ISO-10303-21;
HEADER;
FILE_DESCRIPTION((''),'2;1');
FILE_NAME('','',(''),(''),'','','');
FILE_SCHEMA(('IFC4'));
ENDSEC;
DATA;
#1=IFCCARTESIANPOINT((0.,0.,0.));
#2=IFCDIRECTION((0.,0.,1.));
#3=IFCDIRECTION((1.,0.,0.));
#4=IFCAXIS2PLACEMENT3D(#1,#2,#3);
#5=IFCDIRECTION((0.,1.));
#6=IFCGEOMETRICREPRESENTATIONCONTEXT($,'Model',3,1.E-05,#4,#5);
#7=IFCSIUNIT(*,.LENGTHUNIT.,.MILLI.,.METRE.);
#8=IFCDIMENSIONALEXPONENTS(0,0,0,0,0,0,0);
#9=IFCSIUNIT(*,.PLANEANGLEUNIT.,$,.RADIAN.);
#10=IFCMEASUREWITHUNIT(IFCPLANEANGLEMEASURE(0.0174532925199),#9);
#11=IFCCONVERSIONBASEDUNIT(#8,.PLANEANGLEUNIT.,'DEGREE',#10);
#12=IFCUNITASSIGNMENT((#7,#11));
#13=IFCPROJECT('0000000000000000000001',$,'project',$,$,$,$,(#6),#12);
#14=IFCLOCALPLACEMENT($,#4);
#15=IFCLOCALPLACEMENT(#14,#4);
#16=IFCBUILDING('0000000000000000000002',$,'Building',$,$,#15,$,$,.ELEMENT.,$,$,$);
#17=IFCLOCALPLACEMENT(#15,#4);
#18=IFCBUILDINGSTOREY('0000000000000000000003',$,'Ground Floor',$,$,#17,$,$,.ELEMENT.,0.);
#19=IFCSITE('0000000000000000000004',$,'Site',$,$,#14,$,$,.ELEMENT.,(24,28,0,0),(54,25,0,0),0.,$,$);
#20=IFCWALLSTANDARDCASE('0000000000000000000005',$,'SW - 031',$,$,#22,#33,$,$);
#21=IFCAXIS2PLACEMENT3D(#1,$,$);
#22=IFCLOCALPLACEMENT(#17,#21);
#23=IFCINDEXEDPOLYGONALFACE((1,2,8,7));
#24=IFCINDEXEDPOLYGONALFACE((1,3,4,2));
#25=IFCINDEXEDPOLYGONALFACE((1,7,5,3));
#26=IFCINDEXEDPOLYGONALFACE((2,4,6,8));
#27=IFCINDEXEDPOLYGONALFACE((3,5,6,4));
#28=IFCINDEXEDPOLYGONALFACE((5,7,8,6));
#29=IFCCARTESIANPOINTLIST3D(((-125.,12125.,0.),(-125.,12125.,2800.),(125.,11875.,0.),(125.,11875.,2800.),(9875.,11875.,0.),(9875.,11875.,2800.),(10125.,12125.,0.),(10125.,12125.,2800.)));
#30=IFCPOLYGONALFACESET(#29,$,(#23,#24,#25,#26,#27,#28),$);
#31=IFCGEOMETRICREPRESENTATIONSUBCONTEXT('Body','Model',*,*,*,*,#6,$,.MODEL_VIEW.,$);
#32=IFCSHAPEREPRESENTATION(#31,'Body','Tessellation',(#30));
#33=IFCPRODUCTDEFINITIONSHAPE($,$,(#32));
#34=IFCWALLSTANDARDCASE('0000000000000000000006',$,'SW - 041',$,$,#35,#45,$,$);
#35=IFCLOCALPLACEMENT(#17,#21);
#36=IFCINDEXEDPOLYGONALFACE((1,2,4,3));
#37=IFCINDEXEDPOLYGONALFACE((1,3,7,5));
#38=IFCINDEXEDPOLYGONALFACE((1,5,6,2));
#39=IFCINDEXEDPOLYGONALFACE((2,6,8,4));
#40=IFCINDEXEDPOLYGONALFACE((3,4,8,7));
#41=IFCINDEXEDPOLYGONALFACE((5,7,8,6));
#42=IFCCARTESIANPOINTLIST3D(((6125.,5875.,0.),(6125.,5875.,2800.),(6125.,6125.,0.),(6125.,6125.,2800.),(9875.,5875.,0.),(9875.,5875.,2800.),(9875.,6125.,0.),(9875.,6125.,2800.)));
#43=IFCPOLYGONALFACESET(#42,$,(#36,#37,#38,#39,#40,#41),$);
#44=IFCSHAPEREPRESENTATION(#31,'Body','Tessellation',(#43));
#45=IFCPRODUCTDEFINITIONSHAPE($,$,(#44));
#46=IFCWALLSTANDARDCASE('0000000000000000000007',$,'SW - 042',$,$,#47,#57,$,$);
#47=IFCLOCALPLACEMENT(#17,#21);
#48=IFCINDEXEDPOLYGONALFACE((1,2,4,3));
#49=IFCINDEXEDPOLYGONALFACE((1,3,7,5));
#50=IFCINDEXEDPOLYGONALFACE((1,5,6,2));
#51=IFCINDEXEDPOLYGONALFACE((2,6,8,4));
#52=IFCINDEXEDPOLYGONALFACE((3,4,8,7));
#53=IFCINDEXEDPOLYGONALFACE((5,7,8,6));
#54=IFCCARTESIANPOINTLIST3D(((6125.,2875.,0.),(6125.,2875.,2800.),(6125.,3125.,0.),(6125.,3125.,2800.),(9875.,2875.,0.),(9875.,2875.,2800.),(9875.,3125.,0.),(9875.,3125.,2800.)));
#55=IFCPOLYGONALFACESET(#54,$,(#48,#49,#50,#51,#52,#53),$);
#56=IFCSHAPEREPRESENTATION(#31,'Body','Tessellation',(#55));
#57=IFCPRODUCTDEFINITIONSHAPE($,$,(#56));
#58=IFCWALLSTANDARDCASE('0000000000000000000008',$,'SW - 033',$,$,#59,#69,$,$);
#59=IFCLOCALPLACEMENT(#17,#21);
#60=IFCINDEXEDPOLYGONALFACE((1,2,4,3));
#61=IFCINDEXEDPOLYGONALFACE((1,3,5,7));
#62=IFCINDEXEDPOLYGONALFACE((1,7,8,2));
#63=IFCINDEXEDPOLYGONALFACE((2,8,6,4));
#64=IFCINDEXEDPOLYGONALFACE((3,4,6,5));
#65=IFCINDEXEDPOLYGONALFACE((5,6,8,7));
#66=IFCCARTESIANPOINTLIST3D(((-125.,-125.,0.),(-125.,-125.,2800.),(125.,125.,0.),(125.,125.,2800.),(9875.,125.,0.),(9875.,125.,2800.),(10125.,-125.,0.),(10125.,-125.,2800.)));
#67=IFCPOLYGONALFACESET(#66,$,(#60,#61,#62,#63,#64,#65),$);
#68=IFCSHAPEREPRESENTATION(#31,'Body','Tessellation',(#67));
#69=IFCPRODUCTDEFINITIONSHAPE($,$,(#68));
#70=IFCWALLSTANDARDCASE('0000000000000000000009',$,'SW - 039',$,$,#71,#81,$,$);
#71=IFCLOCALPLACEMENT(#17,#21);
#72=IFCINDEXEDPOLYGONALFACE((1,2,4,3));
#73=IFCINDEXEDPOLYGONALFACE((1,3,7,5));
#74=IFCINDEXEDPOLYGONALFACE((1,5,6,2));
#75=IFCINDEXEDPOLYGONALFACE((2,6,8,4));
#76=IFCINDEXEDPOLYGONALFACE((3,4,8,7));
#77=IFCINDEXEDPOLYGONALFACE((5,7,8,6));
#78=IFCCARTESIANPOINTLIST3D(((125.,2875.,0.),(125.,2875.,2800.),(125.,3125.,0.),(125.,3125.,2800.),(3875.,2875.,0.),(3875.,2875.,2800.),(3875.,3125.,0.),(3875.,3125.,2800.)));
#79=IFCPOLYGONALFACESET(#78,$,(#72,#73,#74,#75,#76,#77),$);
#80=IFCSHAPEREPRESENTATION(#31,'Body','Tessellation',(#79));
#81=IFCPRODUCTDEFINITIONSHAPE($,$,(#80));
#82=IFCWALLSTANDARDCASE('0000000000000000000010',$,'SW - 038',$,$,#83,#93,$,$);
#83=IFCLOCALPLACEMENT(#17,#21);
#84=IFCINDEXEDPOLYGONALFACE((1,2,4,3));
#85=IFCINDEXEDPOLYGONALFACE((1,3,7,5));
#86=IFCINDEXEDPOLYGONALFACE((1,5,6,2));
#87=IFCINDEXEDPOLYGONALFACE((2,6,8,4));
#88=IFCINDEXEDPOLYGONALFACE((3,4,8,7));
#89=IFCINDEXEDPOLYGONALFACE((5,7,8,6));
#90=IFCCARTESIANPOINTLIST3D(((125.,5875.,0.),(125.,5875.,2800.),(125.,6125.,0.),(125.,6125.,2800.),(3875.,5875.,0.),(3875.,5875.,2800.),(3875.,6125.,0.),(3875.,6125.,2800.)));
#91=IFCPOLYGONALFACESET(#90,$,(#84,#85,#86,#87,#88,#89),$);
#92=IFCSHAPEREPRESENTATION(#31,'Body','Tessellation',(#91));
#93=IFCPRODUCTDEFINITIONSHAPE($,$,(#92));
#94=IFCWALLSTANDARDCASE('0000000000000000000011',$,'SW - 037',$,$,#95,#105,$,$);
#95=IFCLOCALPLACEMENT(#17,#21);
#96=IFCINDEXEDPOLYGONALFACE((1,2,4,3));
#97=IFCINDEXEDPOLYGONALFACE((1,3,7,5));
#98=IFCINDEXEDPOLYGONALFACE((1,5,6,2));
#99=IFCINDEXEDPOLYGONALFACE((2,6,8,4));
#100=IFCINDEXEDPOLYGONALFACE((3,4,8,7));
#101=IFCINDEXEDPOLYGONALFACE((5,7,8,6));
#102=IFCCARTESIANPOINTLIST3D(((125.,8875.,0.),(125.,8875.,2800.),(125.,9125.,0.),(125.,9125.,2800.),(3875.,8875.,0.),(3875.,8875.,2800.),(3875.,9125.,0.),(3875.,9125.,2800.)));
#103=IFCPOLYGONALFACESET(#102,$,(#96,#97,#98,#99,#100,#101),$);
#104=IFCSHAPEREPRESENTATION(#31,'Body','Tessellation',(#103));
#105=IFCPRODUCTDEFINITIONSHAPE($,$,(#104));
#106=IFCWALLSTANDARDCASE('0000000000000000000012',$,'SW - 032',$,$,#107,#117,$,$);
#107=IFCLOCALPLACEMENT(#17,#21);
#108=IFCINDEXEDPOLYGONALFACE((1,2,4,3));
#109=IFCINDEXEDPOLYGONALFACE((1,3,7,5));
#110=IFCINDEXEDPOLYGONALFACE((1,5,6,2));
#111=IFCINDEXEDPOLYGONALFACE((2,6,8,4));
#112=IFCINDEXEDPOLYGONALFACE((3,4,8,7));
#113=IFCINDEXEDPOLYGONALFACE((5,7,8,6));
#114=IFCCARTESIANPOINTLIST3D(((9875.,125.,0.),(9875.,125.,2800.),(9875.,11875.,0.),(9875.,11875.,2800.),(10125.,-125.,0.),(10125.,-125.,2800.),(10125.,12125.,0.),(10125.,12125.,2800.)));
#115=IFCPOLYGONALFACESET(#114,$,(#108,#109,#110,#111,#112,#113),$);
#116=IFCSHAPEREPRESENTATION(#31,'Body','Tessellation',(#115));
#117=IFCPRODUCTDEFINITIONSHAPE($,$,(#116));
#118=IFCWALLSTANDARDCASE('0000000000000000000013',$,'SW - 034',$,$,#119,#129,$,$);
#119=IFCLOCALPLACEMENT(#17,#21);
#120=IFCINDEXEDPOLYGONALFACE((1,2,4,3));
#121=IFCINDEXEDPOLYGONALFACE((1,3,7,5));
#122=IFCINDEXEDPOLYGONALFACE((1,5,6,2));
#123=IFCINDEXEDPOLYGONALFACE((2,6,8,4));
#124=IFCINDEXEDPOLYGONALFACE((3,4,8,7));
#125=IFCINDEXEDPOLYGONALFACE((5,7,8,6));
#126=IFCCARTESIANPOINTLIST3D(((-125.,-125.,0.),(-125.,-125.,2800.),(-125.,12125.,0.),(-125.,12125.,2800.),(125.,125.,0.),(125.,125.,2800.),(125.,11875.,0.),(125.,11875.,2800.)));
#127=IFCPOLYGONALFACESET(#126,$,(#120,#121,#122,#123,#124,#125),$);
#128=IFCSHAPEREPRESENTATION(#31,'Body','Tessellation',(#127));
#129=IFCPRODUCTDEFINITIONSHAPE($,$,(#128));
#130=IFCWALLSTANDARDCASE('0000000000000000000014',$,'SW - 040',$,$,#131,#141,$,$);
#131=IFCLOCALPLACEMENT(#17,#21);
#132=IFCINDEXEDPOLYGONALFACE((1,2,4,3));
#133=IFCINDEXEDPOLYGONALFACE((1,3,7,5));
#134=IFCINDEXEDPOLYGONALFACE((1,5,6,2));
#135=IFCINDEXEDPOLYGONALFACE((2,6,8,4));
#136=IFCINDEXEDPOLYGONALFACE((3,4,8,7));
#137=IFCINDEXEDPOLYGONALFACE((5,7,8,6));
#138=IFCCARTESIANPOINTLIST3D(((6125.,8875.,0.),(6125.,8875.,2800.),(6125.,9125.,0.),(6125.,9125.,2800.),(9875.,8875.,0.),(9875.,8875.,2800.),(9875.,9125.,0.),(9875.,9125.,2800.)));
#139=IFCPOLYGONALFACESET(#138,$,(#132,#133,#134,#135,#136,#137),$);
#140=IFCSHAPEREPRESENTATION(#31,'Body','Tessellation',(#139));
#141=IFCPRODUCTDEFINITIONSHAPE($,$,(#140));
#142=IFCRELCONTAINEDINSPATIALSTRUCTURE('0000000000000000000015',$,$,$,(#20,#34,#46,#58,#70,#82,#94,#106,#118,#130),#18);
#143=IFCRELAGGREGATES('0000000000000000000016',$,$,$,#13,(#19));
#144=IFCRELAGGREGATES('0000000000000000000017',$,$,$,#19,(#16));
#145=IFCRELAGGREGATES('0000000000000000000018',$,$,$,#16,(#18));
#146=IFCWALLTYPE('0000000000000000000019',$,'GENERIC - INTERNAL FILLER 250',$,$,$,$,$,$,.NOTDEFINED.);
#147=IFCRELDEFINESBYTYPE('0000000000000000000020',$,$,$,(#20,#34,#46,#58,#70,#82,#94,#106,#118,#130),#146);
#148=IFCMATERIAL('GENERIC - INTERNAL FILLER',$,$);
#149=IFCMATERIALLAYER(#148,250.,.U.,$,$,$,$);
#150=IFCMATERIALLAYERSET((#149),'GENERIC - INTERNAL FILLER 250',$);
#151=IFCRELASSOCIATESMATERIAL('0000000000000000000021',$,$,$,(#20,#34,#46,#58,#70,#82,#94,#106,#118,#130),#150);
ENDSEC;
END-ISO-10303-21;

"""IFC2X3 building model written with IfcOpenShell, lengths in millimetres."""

from ifc_helpers import new_model, entity, si_unit, converted_unit, direction, frame, origin_with_axes, place, context, subcontext, project, spatial, polyline, outline, extrude, material, layer, layer_set, layer_usage, type_object, element, save


model = new_model("IFC2X3")

# Units and contexts
model_context = context("Model", 3, precision=1e-05, world=origin_with_axes(), true_north=direction((0.0, 1.0)))
body_context = subcontext(model_context, "Body", "Model", "MODEL_VIEW")
ifc_project = project(units=[si_unit("LENGTHUNIT", "METRE", prefix="MILLI"), converted_unit("PLANEANGLEUNIT", "DEGREE", entity("IfcPlaneAngleMeasure", 0.0174532925199), si_unit("PLANEANGLEUNIT", "RADIAN"), dimensions=[0, 0, 0, 0, 0, 0, 0])], contexts=[model_context])

# Site, building, storey
site_placement = place(None, origin_with_axes())
site = spatial("IfcSite", under=ifc_project, at=site_placement, Name="Site", CompositionType="ELEMENT", RefLatitude=(24, 28, 0, 0), RefLongitude=(54, 25, 0, 0), RefElevation=0.0)
building_placement = place(site_placement, origin_with_axes())
building = spatial("IfcBuilding", under=site, at=building_placement, Name="Building", CompositionType="ELEMENT")
storey_placement = place(building_placement, origin_with_axes())
storey = spatial("IfcBuildingStorey", under=building, at=storey_placement, Name="Ground Floor", CompositionType="ELEMENT", Elevation=0.0)

# Wall
ifc_material = material(Name="GENERIC - INTERNAL FILLER")
ifc_layer = layer(ifc_material, 250.0, ventilated="UNKNOWN")
ifc_layer_set = layer_set([ifc_layer], Name="GENERIC - INTERNAL FILLER 250")
ifc_layer_usage_1 = layer_usage(ifc_layer_set, "AXIS2", "POSITIVE", -125.0)
wall_type = type_object("IfcWallType", Name="GENERIC - INTERNAL FILLER 250", PredefinedType="NOTDEFINED")
wall_1_placement = place(storey_placement, frame((0.0, 12000.0, 0.0), z_axis=(0.0, 0.0, 1.0), x_axis=(1.0, 0.0, 0.0)))
element("IfcWallStandardCase", 1, at=wall_1_placement, inside=storey, type_object=wall_type, material=ifc_layer_usage_1, Name="SW - 031", context=body_context, shape_type="SweptSolid", body=[
    extrude(outline(polyline([(125.0, -125.0), (9875.0, -125.0), (10125.0, 125.0), (-125.0, 125.0), (125.0, -125.0)])), origin_with_axes(), (0.0, 0.0, 1.0), 2800.0),
])

# Walls
ifc_layer_usage_2 = layer_usage(ifc_layer_set, "AXIS2", "POSITIVE", -125.0)
wall_2_placement = place(storey_placement, frame((6000.0, 6000.0, 0.0), z_axis=(0.0, 0.0, 1.0), x_axis=(1.0, 0.0, 0.0)))
element("IfcWallStandardCase", 2, at=wall_2_placement, inside=storey, type_object=wall_type, material=ifc_layer_usage_2, Name="SW - 041", context=body_context, shape_type="SweptSolid", body=[
    extrude(outline(polyline([(125.0, -125.0), (3875.0, -125.0), (3875.0, 125.0), (125.0, 125.0), (125.0, -125.0)])), origin_with_axes(), (0.0, 0.0, 1.0), 2800.0),
])
ifc_layer_usage_3 = layer_usage(ifc_layer_set, "AXIS2", "POSITIVE", -125.0)
wall_3_placement = place(storey_placement, frame((6000.0, 3000.0, 0.0), z_axis=(0.0, 0.0, 1.0), x_axis=(1.0, 0.0, 0.0)))
element("IfcWallStandardCase", 3, at=wall_3_placement, inside=storey, type_object=wall_type, material=ifc_layer_usage_3, Name="SW - 042", context=body_context, shape_type="SweptSolid", body=[
    extrude(outline(polyline([(125.0, -125.0), (3875.0, -125.0), (3875.0, 125.0), (125.0, 125.0), (125.0, -125.0)])), origin_with_axes(), (0.0, 0.0, 1.0), 2800.0),
])
ifc_layer_usage_4 = layer_usage(ifc_layer_set, "AXIS2", "POSITIVE", -125.0)
wall_4_placement = place(storey_placement, frame((10000.0, 0.0, 0.0), z_axis=(0.0, 0.0, 1.0), x_axis=(-1.0, 0.0, 0.0)))
element("IfcWallStandardCase", 4, at=wall_4_placement, inside=storey, type_object=wall_type, material=ifc_layer_usage_4, Name="SW - 033", context=body_context, shape_type="SweptSolid", body=[
    extrude(outline(polyline([(125.0, -125.0), (9875.0, -125.0), (10125.0, 125.0), (-125.0, 125.0), (125.0, -125.0)])), origin_with_axes(), (0.0, 0.0, 1.0), 2800.0),
])

# Walls
ifc_layer_usage_5 = layer_usage(ifc_layer_set, "AXIS2", "POSITIVE", -125.0)
wall_5_placement = place(storey_placement, frame((0.0, 3000.0, 0.0), z_axis=(0.0, 0.0, 1.0), x_axis=(1.0, 0.0, 0.0)))
element("IfcWallStandardCase", 5, at=wall_5_placement, inside=storey, type_object=wall_type, material=ifc_layer_usage_5, Name="SW - 039", context=body_context, shape_type="SweptSolid", body=[
    extrude(outline(polyline([(125.0, -125.0), (3875.0, -125.0), (3875.0, 125.0), (125.0, 125.0), (125.0, -125.0)])), origin_with_axes(), (0.0, 0.0, 1.0), 2800.0),
])
ifc_layer_usage_6 = layer_usage(ifc_layer_set, "AXIS2", "POSITIVE", -125.0)
wall_6_placement = place(storey_placement, frame((0.0, 6000.0, 0.0), z_axis=(0.0, 0.0, 1.0), x_axis=(1.0, 0.0, 0.0)))
element("IfcWallStandardCase", 6, at=wall_6_placement, inside=storey, type_object=wall_type, material=ifc_layer_usage_6, Name="SW - 038", context=body_context, shape_type="SweptSolid", body=[
    extrude(outline(polyline([(125.0, -125.0), (3875.0, -125.0), (3875.0, 125.0), (125.0, 125.0), (125.0, -125.0)])), origin_with_axes(), (0.0, 0.0, 1.0), 2800.0),
])
ifc_layer_usage_7 = layer_usage(ifc_layer_set, "AXIS2", "POSITIVE", -125.0)
wall_7_placement = place(storey_placement, frame((0.0, 9000.0, 0.0), z_axis=(0.0, 0.0, 1.0), x_axis=(1.0, 0.0, 0.0)))
element("IfcWallStandardCase", 7, at=wall_7_placement, inside=storey, type_object=wall_type, material=ifc_layer_usage_7, Name="SW - 037", context=body_context, shape_type="SweptSolid", body=[
    extrude(outline(polyline([(125.0, -125.0), (3875.0, -125.0), (3875.0, 125.0), (125.0, 125.0), (125.0, -125.0)])), origin_with_axes(), (0.0, 0.0, 1.0), 2800.0),
])
ifc_layer_usage_8 = layer_usage(ifc_layer_set, "AXIS2", "POSITIVE", -125.0)
wall_8_placement = place(storey_placement, frame((10000.0, 12000.0, 0.0), z_axis=(0.0, 0.0, 1.0), x_axis=(0.0, -1.0, 0.0)))
element("IfcWallStandardCase", 8, at=wall_8_placement, inside=storey, type_object=wall_type, material=ifc_layer_usage_8, Name="SW - 032", context=body_context, shape_type="SweptSolid", body=[
    extrude(outline(polyline([(125.0, -125.0), (11875.0, -125.0), (12125.0, 125.0), (-125.0, 125.0), (125.0, -125.0)])), origin_with_axes(), (0.0, 0.0, 1.0), 2800.0),
])
ifc_layer_usage_9 = layer_usage(ifc_layer_set, "AXIS2", "POSITIVE", -125.0)
wall_9_placement = place(storey_placement, frame((0.0, 0.0, 0.0), z_axis=(0.0, 0.0, 1.0), x_axis=(0.0, 1.0, 0.0)))
element("IfcWallStandardCase", 9, at=wall_9_placement, inside=storey, type_object=wall_type, material=ifc_layer_usage_9, Name="SW - 034", context=body_context, shape_type="SweptSolid", body=[
    extrude(outline(polyline([(125.0, -125.0), (11875.0, -125.0), (12125.0, 125.0), (-125.0, 125.0), (125.0, -125.0)])), origin_with_axes(), (0.0, 0.0, 1.0), 2800.0),
])
ifc_layer_usage_10 = layer_usage(ifc_layer_set, "AXIS2", "POSITIVE", -125.0)
wall_10_placement = place(storey_placement, frame((6000.0, 9000.0, 0.0), z_axis=(0.0, 0.0, 1.0), x_axis=(1.0, 0.0, 0.0)))
element("IfcWallStandardCase", 10, at=wall_10_placement, inside=storey, type_object=wall_type, material=ifc_layer_usage_10, Name="SW - 040", context=body_context, shape_type="SweptSolid", body=[
    extrude(outline(polyline([(125.0, -125.0), (3875.0, -125.0), (3875.0, 125.0), (125.0, 125.0), (125.0, -125.0)])), origin_with_axes(), (0.0, 0.0, 1.0), 2800.0),
])

save(model, "model.ifc")
